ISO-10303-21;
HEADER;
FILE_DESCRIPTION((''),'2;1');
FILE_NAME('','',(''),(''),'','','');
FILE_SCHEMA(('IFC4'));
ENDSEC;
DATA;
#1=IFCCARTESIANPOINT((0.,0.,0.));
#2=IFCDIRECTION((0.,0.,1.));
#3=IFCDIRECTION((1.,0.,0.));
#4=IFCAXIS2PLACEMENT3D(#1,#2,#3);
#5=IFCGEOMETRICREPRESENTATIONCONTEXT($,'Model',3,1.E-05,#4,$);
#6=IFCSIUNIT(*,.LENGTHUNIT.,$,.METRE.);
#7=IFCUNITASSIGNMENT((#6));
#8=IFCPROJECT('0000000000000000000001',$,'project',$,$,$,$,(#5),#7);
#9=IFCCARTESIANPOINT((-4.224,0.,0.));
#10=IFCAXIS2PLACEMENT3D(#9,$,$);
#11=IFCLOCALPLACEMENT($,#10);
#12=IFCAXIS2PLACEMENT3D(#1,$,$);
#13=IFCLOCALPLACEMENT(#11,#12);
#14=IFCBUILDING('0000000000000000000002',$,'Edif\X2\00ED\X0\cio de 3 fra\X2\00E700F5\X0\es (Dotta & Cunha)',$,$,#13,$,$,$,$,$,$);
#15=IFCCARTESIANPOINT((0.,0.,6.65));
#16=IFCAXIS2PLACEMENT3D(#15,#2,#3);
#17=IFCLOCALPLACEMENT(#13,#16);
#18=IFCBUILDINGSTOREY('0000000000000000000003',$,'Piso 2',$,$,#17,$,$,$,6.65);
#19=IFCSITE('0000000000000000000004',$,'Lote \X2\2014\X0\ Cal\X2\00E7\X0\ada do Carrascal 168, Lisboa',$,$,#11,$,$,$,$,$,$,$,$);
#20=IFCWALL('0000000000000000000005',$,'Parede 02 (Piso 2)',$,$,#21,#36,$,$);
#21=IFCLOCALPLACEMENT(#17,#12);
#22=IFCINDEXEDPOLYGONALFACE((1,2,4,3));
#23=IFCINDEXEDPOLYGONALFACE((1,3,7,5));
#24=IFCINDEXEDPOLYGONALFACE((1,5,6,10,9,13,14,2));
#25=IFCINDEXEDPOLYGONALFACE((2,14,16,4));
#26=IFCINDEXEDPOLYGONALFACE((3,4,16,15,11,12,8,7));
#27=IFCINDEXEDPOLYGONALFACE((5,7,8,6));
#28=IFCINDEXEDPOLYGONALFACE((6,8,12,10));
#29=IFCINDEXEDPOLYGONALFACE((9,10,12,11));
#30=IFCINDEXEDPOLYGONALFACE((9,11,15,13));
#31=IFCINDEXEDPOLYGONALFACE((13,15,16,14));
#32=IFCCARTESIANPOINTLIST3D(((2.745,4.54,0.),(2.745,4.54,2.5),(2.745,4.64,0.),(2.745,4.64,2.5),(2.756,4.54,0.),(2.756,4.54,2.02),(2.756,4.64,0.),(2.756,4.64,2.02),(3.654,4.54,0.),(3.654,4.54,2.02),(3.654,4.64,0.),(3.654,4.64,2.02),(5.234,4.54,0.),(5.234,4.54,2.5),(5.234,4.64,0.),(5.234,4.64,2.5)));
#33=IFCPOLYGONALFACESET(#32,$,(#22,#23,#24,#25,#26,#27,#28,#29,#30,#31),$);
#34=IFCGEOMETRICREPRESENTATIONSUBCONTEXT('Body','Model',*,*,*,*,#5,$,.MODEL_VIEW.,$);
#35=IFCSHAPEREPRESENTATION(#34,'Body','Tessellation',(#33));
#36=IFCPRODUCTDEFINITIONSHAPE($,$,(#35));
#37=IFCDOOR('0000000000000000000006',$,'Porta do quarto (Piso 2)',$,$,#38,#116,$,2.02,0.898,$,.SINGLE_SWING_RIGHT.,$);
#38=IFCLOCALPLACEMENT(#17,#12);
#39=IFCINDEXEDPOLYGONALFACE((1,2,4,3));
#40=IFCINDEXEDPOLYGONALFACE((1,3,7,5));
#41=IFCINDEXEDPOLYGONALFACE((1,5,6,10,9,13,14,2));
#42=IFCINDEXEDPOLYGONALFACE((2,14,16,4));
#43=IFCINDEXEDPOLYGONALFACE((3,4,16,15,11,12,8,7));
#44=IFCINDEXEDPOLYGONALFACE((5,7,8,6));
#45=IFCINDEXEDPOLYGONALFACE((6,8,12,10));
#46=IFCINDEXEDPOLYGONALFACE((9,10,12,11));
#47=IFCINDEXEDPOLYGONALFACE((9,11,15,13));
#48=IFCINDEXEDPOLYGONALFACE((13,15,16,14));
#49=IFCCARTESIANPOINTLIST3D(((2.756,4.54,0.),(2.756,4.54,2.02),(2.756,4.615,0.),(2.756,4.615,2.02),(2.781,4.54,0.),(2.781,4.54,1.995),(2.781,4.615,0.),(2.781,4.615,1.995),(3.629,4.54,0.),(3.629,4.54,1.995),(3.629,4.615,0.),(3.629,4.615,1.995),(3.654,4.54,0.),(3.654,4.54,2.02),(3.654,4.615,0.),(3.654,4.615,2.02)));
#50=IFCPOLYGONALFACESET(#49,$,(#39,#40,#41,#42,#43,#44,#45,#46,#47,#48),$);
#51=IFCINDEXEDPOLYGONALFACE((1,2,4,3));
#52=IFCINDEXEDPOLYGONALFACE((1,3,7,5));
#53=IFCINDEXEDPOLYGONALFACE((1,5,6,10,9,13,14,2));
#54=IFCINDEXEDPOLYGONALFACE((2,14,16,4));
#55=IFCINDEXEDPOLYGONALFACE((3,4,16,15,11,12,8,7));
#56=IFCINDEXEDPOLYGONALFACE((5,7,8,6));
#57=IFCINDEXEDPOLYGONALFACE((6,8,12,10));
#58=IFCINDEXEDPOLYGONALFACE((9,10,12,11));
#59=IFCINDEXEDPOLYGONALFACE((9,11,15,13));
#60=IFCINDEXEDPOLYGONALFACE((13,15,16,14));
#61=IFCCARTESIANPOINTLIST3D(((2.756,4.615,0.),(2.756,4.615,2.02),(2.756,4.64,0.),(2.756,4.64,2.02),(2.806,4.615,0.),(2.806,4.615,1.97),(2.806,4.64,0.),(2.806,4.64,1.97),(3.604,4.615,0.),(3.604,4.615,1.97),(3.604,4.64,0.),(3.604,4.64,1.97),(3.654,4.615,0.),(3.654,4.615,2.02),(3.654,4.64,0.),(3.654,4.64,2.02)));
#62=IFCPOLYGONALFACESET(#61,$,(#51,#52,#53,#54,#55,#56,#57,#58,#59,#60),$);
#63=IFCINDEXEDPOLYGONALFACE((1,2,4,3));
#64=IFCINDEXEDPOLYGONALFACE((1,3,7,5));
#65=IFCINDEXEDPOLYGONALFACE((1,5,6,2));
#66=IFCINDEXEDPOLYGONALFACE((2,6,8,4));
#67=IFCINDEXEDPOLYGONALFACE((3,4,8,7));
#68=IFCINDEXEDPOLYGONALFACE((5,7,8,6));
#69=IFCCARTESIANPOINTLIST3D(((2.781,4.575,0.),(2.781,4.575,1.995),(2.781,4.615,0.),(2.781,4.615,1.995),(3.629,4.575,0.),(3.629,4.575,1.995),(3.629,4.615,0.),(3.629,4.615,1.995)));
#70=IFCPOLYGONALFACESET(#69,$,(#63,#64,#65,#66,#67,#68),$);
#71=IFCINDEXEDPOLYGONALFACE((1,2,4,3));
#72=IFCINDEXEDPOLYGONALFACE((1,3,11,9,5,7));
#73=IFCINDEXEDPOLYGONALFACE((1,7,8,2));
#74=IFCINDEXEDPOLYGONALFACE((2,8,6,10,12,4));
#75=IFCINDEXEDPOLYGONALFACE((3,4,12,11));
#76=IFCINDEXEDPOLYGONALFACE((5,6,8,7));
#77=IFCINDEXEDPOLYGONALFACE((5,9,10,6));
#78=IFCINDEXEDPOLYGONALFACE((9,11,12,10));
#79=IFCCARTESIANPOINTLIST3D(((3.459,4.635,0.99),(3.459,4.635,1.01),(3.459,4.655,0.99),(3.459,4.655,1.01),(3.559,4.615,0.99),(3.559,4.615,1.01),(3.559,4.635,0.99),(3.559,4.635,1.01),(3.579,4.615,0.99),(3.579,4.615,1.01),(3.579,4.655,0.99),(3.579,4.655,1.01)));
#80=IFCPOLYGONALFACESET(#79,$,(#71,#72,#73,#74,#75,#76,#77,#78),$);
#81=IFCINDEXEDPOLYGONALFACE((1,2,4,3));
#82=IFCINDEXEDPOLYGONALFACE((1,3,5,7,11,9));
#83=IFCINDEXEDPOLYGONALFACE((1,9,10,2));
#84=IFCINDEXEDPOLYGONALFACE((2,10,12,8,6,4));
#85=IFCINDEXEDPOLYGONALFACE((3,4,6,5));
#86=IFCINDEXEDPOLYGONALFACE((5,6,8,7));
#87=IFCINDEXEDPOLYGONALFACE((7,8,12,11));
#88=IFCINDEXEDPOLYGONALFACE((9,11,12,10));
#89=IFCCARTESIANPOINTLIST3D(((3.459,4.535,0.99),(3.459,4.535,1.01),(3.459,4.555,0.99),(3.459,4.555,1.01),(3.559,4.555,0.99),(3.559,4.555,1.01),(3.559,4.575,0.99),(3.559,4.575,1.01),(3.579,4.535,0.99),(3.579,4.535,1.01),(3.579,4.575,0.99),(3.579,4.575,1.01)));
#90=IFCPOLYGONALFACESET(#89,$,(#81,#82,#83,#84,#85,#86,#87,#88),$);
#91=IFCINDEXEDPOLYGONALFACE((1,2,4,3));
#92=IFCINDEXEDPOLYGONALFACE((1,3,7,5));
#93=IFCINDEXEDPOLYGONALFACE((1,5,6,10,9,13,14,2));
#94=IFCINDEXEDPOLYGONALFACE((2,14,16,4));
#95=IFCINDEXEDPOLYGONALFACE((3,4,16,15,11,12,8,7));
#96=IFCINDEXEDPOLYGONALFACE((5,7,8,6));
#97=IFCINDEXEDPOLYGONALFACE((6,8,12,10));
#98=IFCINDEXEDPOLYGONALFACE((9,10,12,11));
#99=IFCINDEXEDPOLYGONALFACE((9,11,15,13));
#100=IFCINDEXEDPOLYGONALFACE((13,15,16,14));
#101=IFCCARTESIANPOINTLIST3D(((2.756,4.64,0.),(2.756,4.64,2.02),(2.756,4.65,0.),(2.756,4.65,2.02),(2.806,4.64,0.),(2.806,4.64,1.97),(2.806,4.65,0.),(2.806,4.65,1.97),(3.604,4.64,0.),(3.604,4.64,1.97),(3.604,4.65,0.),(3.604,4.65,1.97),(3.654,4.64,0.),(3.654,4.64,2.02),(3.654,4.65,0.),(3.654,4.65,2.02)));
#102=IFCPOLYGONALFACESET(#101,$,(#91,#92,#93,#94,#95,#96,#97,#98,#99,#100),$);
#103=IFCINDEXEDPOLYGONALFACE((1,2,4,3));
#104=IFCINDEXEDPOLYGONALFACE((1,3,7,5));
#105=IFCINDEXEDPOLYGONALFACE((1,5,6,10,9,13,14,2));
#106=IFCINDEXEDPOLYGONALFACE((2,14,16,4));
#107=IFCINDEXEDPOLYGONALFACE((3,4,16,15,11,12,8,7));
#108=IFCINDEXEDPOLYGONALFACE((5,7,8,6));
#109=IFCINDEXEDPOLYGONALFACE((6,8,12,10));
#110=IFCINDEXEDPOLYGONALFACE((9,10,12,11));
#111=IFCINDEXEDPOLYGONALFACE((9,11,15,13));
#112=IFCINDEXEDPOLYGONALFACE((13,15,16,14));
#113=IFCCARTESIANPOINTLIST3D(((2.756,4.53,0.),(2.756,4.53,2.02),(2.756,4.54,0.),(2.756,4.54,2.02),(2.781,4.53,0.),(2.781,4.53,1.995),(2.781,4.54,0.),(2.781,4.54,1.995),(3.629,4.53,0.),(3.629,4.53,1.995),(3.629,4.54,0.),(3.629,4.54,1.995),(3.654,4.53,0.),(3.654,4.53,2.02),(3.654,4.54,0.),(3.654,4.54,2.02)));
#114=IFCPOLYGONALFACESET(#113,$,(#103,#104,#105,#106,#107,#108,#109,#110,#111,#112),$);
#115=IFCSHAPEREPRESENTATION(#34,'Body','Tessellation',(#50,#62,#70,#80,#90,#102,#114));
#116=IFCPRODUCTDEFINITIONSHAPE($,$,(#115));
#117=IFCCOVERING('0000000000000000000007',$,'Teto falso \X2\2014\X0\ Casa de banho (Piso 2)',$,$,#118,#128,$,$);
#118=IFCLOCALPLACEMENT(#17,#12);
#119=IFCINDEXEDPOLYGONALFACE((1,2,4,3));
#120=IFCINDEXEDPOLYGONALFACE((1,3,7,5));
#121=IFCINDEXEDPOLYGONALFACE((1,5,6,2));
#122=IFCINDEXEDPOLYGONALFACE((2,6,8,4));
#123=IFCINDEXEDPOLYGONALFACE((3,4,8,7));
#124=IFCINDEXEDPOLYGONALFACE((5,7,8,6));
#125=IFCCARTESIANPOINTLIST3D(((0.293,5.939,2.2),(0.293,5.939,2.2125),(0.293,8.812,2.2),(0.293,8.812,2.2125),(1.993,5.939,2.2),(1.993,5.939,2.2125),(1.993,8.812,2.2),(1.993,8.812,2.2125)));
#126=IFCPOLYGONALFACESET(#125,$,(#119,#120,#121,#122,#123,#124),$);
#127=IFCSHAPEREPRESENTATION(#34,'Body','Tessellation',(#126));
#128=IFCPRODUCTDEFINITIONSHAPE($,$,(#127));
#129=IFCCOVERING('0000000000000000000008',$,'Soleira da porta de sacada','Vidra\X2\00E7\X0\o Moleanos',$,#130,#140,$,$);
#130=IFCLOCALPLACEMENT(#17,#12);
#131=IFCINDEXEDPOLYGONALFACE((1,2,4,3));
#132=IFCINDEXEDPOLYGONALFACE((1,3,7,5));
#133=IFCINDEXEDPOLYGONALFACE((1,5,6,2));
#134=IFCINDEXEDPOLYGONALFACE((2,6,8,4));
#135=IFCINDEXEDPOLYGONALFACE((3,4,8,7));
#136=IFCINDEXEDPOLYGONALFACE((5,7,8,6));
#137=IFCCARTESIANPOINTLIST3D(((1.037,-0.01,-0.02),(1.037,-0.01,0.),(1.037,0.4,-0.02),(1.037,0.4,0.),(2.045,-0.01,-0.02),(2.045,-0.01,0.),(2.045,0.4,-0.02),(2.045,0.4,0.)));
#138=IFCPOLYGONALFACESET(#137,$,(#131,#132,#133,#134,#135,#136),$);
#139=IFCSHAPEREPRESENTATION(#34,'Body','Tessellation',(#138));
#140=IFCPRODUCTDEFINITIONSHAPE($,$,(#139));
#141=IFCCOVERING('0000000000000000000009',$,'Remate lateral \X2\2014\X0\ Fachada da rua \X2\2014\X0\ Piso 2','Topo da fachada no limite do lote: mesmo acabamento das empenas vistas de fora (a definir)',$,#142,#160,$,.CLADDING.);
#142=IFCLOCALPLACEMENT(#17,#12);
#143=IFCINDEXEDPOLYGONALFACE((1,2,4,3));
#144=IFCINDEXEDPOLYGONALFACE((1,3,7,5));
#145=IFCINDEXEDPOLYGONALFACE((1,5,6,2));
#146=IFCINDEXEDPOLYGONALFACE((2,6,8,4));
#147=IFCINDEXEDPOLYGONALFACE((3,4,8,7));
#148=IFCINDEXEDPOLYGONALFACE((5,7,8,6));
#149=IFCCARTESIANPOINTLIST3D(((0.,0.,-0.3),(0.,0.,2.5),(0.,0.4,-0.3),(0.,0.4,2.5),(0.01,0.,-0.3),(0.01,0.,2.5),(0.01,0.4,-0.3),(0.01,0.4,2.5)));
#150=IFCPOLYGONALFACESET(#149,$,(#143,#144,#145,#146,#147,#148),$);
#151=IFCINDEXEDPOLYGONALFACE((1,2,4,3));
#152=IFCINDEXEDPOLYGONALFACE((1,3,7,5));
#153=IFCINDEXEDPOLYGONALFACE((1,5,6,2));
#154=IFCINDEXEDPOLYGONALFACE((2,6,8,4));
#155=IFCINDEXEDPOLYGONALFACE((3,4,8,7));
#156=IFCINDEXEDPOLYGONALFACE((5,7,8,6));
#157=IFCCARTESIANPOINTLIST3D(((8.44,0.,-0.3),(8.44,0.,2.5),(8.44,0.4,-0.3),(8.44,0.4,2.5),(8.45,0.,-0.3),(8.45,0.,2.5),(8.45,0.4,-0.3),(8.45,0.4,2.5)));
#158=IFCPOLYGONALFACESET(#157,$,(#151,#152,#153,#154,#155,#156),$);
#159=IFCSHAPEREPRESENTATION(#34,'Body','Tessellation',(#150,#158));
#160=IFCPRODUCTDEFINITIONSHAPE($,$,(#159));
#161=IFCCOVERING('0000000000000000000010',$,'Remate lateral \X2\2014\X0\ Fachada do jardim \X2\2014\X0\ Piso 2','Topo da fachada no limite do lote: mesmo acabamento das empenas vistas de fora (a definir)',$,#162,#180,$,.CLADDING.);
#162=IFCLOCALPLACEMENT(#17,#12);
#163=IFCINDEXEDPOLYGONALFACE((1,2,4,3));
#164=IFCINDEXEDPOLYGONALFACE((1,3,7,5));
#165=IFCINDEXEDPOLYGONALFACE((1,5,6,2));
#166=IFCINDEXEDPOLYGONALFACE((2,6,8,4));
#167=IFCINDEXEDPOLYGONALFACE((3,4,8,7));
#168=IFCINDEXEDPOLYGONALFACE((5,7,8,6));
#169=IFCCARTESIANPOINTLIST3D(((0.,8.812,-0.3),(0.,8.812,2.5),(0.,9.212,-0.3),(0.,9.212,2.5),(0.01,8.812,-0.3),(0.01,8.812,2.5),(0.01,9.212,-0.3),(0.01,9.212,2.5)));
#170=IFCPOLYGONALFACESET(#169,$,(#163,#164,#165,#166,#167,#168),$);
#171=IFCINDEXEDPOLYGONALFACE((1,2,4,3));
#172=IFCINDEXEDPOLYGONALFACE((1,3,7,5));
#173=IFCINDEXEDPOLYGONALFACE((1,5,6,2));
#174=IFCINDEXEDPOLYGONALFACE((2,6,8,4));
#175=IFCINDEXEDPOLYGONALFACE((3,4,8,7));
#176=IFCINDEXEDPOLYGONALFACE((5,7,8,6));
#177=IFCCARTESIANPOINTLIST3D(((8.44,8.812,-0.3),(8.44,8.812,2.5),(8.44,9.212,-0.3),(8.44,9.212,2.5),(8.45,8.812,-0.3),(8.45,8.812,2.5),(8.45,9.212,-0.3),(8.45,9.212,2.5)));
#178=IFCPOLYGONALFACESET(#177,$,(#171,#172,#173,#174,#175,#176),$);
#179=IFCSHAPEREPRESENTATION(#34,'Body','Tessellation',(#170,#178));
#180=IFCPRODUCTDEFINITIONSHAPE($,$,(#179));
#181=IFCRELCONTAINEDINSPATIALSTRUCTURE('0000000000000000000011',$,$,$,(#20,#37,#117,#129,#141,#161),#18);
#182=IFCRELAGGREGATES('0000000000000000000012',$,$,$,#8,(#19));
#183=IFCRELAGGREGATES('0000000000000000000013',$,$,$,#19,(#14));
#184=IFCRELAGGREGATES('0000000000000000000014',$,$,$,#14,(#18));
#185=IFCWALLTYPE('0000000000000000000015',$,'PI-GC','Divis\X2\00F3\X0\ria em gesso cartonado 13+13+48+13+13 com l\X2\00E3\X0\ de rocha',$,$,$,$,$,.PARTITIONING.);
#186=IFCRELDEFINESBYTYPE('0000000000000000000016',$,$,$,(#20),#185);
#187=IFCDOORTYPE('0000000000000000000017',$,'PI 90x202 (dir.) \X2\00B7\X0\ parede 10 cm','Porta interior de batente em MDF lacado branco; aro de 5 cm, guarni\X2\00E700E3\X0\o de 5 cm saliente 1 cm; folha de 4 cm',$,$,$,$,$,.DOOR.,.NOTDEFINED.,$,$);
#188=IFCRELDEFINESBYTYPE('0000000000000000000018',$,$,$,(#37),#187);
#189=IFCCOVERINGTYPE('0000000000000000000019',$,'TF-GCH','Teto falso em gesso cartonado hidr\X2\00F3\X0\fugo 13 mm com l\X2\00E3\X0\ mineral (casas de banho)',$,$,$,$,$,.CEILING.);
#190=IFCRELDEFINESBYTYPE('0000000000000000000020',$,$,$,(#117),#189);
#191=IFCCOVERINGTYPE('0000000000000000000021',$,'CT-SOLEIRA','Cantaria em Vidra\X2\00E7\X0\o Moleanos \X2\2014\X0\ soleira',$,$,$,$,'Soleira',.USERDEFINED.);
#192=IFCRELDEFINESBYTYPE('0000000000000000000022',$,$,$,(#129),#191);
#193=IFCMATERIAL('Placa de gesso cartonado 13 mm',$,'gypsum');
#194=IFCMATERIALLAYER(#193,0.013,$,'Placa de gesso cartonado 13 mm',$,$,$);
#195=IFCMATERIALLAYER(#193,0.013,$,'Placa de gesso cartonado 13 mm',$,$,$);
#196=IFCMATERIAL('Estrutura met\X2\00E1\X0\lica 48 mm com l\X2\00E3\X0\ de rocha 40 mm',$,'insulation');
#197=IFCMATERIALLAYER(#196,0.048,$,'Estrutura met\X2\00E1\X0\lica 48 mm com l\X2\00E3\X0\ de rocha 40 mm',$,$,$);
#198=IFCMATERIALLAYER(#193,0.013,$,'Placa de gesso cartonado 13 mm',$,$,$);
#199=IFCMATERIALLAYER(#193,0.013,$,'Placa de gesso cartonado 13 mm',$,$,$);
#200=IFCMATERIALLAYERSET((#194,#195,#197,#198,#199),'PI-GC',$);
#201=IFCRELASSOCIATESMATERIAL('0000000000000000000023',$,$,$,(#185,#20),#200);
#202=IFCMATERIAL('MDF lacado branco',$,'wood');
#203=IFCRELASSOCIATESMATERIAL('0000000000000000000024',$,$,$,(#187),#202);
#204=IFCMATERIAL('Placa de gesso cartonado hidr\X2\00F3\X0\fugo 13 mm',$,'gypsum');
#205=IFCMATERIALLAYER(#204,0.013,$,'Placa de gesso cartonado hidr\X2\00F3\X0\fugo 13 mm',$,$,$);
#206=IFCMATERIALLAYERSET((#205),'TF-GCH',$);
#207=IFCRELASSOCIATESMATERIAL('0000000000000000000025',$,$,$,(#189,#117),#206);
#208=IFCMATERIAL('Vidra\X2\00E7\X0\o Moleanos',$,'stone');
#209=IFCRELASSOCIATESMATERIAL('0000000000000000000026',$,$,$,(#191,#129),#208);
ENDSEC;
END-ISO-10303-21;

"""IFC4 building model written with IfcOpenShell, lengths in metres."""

from ifc_helpers import new_model, si_unit, frame, origin, origin_with_axes, place, context, subcontext, project, spatial, line, indexed_curve, outline, extrude, source, transform, mapped, material, layer, layer_set, layer_usage, type_object, type_shapes, element, fill, save


model = new_model("IFC4")

# Units and contexts
model_context = context("Model", 3, precision=1e-05, world=origin_with_axes())
body_context = subcontext(model_context, "Body", "Model", "MODEL_VIEW")
ifc_project = project(units=[si_unit("LENGTHUNIT", "METRE")], contexts=[model_context])

# Site, building, storey
site_placement = place(None, frame((-4.224, 0.0, 0.0)))
site = spatial("IfcSite", under=ifc_project, at=site_placement, Name="Lote — Calçada do Carrascal 168, Lisboa")
building_placement = place(site_placement, origin())
building = spatial("IfcBuilding", under=site, at=building_placement, Name="Edifício de 3 frações (Dotta & Cunha)")
storey_placement = place(building_placement, frame((0.0, 0.0, 6.65), z_axis=(0.0, 0.0, 1.0), x_axis=(1.0, 0.0, 0.0)))
storey = spatial("IfcBuildingStorey", under=building, at=storey_placement, Name="Piso 2", Elevation=6.65)

# Shared definitions
ifc_material_1 = material(Name="MDF lacado branco", Category="wood")

# Shared definitions
ifc_material_2 = material(Name="Placa de gesso cartonado 13 mm", Category="gypsum")
ifc_layer_1 = layer(ifc_material_2, 0.013, Name="Placa de gesso cartonado 13 mm")
ifc_layer_2 = layer(ifc_material_2, 0.013, Name="Placa de gesso cartonado 13 mm")
ifc_material_3 = material(Name="Estrutura metálica 48 mm com lã de rocha 40 mm", Category="insulation")
ifc_layer_3 = layer(ifc_material_3, 0.048, Name="Estrutura metálica 48 mm com lã de rocha 40 mm")
ifc_layer_4 = layer(ifc_material_2, 0.013, Name="Placa de gesso cartonado 13 mm")
ifc_layer_5 = layer(ifc_material_2, 0.013, Name="Placa de gesso cartonado 13 mm")
ifc_layer_set_1 = layer_set([ifc_layer_1, ifc_layer_2, ifc_layer_3, ifc_layer_4, ifc_layer_5], Name="PI-GC")
wall_type_1 = type_object("IfcWallType", Name="PI-GC", Description="Divisória em gesso cartonado 13+13+48+13+13 com lã de rocha", PredefinedType="PARTITIONING", material=ifc_layer_set_1)

# Wall, opening, door
ifc_layer_usage_1 = layer_usage(ifc_layer_set_1, "AXIS2", "POSITIVE", 0.0)
wall_1_placement = place(storey_placement, origin_with_axes())
wall_1 = element("IfcWall", 1, at=wall_1_placement, inside=storey, type_object=wall_type_1, material=ifc_layer_usage_1, Name="Parede 02 (Piso 2)", context=body_context, shape_type="SweptSolid", body=[
    extrude(outline(indexed_curve([(5.234, 4.54), (5.234, 4.64), (2.745, 4.64), (2.745, 4.54)], segments=[line(1, 2, 3, 4, 1)])), origin_with_axes(), (0.0, 0.0, 1.0), 2.5),
])
opening_1_placement = place(wall_1_placement, origin_with_axes())
opening_1 = element("IfcOpeningElement", 2, at=opening_1_placement, cuts=wall_1, context=body_context, shape_type="SweptSolid", body=[
    extrude(outline(indexed_curve([(3.654, 4.538), (3.654, 4.642), (2.756, 4.642), (2.756, 4.538)], segments=[line(1, 2, 3, 4, 1)])), origin_with_axes(), (0.0, 0.0, 1.0), 2.02),
])
door_type_1 = type_object("IfcDoorType", Name="PI 90x202 (dir.) · parede 10 cm", Description="Porta interior de batente em MDF lacado branco; aro de 5 cm, guarnição de 5 cm saliente 1 cm; folha de 4 cm", OperationType="NOTDEFINED", PredefinedType="DOOR", material=ifc_material_1)
shared_shape_1 = source(origin_with_axes(), body_context, "Body", "SweptSolid", [
    extrude(outline(indexed_curve([(0.0, 0.0), (0.0, 2.02), (0.898, 2.02), (0.898, 0.0), (0.873, 0.0), (0.873, 1.995), (0.025, 1.995), (0.025, 0.0)], segments=[line(1, 2, 3, 4, 5, 6, 7, 8, 1)])), frame((0.0, 0.025, 0.0), z_axis=(0.0, -1.0, 0.0), x_axis=(1.0, 0.0, 0.0)), (0.0, 0.0, -1.0), 0.075),
    extrude(outline(indexed_curve([(0.0, 0.0), (0.0, 2.02), (0.898, 2.02), (0.898, 0.0), (0.848, 0.0), (0.848, 1.97), (0.05, 1.97), (0.05, 0.0)], segments=[line(1, 2, 3, 4, 5, 6, 7, 8, 1)])), frame((0.0, 0.0, 0.0), z_axis=(0.0, -1.0, 0.0), x_axis=(1.0, 0.0, 0.0)), (0.0, 0.0, -1.0), 0.025),
    extrude(outline(indexed_curve([(0.0, 0.0), (0.848, 0.0), (0.848, 0.04), (0.0, 0.04)], segments=[line(1, 2, 3, 4, 1)])), frame((0.025, 0.025, 0.0), z_axis=(0.0, 0.0, 1.0), x_axis=(1.0, 0.0, 0.0)), (0.0, 0.0, 1.0), 1.995),
    extrude(outline(indexed_curve([(0.0, 0.0), (0.0, -0.04), (0.12, -0.04), (0.12, -0.02), (0.02, -0.02), (0.02, 0.0)], segments=[line(1, 2, 3, 4, 5, 6, 1)])), frame((0.075, 0.025, 0.99), z_axis=(0.0, 0.0, 1.0), x_axis=(1.0, 0.0, 0.0)), (0.0, 0.0, 1.0), 0.02),
    extrude(outline(indexed_curve([(0.0, 0.0), (0.0, 0.04), (0.12, 0.04), (0.12, 0.02), (0.02, 0.02), (0.02, 0.0)], segments=[line(1, 2, 3, 4, 5, 6, 1)])), frame((0.075, 0.065, 0.99), z_axis=(0.0, 0.0, 1.0), x_axis=(1.0, 0.0, 0.0)), (0.0, 0.0, 1.0), 0.02),
    extrude(outline(indexed_curve([(0.0, 0.0), (0.0, 2.02), (0.898, 2.02), (0.898, 0.0), (0.848, 0.0), (0.848, 1.97), (0.05, 1.97), (0.05, 0.0)], segments=[line(1, 2, 3, 4, 5, 6, 7, 8, 1)])), frame((0.0, -0.01, 0.0), z_axis=(0.0, -1.0, 0.0), x_axis=(1.0, 0.0, 0.0)), (0.0, 0.0, -1.0), 0.01),
    extrude(outline(indexed_curve([(0.0, 0.0), (0.0, 2.02), (0.898, 2.02), (0.898, 0.0), (0.873, 0.0), (0.873, 1.995), (0.025, 1.995), (0.025, 0.0)], segments=[line(1, 2, 3, 4, 5, 6, 7, 8, 1)])), frame((0.0, 0.1, 0.0), z_axis=(0.0, -1.0, 0.0), x_axis=(1.0, 0.0, 0.0)), (0.0, 0.0, -1.0), 0.01),
])
type_shapes(door_type_1, [shared_shape_1])
door_1_placement = place(storey_placement, frame((3.654, 4.64, 0.0), z_axis=(0.0, 0.0, 1.0), x_axis=(-1.0, 0.0, 0.0)))
door_1 = element("IfcDoor", 3, at=door_1_placement, inside=storey, type_object=door_type_1, Name="Porta do quarto (Piso 2)", OperationType="SINGLE_SWING_RIGHT", OverallHeight=2.02, OverallWidth=0.898, context=body_context, shape_type="MappedRepresentation", body=[
    mapped(shared_shape_1, transform((0.0, 0.0, 0.0), x_axis=(1.0, 0.0, 0.0), y_axis=(0.0, 1.0, 0.0), z_axis=(0.0, 0.0, 1.0), scale=1.0)),
])
fill(opening_1, door_1)

# Coverings
ifc_material_4 = material(Name="Placa de gesso cartonado hidrófugo 13 mm", Category="gypsum")
ifc_layer_6 = layer(ifc_material_4, 0.013, Name="Placa de gesso cartonado hidrófugo 13 mm")
ifc_layer_set_2 = layer_set([ifc_layer_6], Name="TF-GCH")
ifc_layer_usage_2 = layer_usage(ifc_layer_set_2, "AXIS3", "POSITIVE", 0.0)
covering_type_1 = type_object("IfcCoveringType", Name="TF-GCH", Description="Teto falso em gesso cartonado hidrófugo 13 mm com lã mineral (casas de banho)", PredefinedType="CEILING", material=ifc_layer_set_2)
covering_1_placement = place(storey_placement, frame((0.0, 0.0, 2.2), z_axis=(0.0, 0.0, 1.0), x_axis=(1.0, 0.0, 0.0)))
element("IfcCovering", 4, at=covering_1_placement, inside=storey, type_object=covering_type_1, material=ifc_layer_usage_2, Name="Teto falso — Casa de banho (Piso 2)", context=body_context, shape_type="SweptSolid", body=[
    extrude(outline(indexed_curve([(1.993, 5.939), (0.293, 5.939), (0.293, 8.812), (1.993, 8.812)], segments=[line(1, 2, 3, 4, 1)])), origin_with_axes(), (0.0, 0.0, 1.0), 0.0125),
])
ifc_material_5 = material(Name="Vidraço Moleanos", Category="stone")
covering_type_2 = type_object("IfcCoveringType", Name="CT-SOLEIRA", Description="Cantaria em Vidraço Moleanos — soleira", ElementType="Soleira", PredefinedType="USERDEFINED", material=ifc_material_5)
covering_2_placement = place(storey_placement, frame((0.0, 0.0, -0.02), z_axis=(0.0, 0.0, 1.0), x_axis=(1.0, 0.0, 0.0)))
element("IfcCovering", 5, at=covering_2_placement, inside=storey, type_object=covering_type_2, material=ifc_material_5, Name="Soleira da porta de sacada", Description="Vidraço Moleanos", context=body_context, shape_type="SweptSolid", body=[
    extrude(outline(indexed_curve([(2.045, -0.01), (2.045, 0.4), (1.037, 0.4), (1.037, -0.01)], segments=[line(1, 2, 3, 4, 1)])), origin_with_axes(), (0.0, 0.0, 1.0), 0.02),
])
covering_3_placement = place(storey_placement, frame((0.0, 0.0, -0.3), z_axis=(0.0, 0.0, 1.0), x_axis=(1.0, 0.0, 0.0)))
element("IfcCovering", 6, at=covering_3_placement, inside=storey, Name="Remate lateral — Fachada da rua — Piso 2", Description="Topo da fachada no limite do lote: mesmo acabamento das empenas vistas de fora (a definir)", PredefinedType="CLADDING", context=body_context, shape_type="SweptSolid", body=[
    extrude(outline(indexed_curve([(0.0, 0.0), (0.0, 0.4), (0.01, 0.4), (0.01, 0.0)], segments=[line(1, 2, 3, 4, 1)])), origin_with_axes(), (0.0, 0.0, 1.0), 2.8),
    extrude(outline(indexed_curve([(8.44, 0.0), (8.44, 0.4), (8.45, 0.4), (8.45, 0.0)], segments=[line(1, 2, 3, 4, 1)])), origin_with_axes(), (0.0, 0.0, 1.0), 2.8),
])
covering_4_placement = place(storey_placement, frame((0.0, 0.0, -0.3), z_axis=(0.0, 0.0, 1.0), x_axis=(1.0, 0.0, 0.0)))
element("IfcCovering", 7, at=covering_4_placement, inside=storey, Name="Remate lateral — Fachada do jardim — Piso 2", Description="Topo da fachada no limite do lote: mesmo acabamento das empenas vistas de fora (a definir)", PredefinedType="CLADDING", context=body_context, shape_type="SweptSolid", body=[
    extrude(outline(indexed_curve([(0.0, 8.812), (0.0, 9.212), (0.01, 9.212), (0.01, 8.812)], segments=[line(1, 2, 3, 4, 1)])), origin_with_axes(), (0.0, 0.0, 1.0), 2.8),
    extrude(outline(indexed_curve([(8.44, 8.812), (8.44, 9.212), (8.45, 9.212), (8.45, 8.812)], segments=[line(1, 2, 3, 4, 1)])), origin_with_axes(), (0.0, 0.0, 1.0), 2.8),
])

save(model, "model.ifc")
